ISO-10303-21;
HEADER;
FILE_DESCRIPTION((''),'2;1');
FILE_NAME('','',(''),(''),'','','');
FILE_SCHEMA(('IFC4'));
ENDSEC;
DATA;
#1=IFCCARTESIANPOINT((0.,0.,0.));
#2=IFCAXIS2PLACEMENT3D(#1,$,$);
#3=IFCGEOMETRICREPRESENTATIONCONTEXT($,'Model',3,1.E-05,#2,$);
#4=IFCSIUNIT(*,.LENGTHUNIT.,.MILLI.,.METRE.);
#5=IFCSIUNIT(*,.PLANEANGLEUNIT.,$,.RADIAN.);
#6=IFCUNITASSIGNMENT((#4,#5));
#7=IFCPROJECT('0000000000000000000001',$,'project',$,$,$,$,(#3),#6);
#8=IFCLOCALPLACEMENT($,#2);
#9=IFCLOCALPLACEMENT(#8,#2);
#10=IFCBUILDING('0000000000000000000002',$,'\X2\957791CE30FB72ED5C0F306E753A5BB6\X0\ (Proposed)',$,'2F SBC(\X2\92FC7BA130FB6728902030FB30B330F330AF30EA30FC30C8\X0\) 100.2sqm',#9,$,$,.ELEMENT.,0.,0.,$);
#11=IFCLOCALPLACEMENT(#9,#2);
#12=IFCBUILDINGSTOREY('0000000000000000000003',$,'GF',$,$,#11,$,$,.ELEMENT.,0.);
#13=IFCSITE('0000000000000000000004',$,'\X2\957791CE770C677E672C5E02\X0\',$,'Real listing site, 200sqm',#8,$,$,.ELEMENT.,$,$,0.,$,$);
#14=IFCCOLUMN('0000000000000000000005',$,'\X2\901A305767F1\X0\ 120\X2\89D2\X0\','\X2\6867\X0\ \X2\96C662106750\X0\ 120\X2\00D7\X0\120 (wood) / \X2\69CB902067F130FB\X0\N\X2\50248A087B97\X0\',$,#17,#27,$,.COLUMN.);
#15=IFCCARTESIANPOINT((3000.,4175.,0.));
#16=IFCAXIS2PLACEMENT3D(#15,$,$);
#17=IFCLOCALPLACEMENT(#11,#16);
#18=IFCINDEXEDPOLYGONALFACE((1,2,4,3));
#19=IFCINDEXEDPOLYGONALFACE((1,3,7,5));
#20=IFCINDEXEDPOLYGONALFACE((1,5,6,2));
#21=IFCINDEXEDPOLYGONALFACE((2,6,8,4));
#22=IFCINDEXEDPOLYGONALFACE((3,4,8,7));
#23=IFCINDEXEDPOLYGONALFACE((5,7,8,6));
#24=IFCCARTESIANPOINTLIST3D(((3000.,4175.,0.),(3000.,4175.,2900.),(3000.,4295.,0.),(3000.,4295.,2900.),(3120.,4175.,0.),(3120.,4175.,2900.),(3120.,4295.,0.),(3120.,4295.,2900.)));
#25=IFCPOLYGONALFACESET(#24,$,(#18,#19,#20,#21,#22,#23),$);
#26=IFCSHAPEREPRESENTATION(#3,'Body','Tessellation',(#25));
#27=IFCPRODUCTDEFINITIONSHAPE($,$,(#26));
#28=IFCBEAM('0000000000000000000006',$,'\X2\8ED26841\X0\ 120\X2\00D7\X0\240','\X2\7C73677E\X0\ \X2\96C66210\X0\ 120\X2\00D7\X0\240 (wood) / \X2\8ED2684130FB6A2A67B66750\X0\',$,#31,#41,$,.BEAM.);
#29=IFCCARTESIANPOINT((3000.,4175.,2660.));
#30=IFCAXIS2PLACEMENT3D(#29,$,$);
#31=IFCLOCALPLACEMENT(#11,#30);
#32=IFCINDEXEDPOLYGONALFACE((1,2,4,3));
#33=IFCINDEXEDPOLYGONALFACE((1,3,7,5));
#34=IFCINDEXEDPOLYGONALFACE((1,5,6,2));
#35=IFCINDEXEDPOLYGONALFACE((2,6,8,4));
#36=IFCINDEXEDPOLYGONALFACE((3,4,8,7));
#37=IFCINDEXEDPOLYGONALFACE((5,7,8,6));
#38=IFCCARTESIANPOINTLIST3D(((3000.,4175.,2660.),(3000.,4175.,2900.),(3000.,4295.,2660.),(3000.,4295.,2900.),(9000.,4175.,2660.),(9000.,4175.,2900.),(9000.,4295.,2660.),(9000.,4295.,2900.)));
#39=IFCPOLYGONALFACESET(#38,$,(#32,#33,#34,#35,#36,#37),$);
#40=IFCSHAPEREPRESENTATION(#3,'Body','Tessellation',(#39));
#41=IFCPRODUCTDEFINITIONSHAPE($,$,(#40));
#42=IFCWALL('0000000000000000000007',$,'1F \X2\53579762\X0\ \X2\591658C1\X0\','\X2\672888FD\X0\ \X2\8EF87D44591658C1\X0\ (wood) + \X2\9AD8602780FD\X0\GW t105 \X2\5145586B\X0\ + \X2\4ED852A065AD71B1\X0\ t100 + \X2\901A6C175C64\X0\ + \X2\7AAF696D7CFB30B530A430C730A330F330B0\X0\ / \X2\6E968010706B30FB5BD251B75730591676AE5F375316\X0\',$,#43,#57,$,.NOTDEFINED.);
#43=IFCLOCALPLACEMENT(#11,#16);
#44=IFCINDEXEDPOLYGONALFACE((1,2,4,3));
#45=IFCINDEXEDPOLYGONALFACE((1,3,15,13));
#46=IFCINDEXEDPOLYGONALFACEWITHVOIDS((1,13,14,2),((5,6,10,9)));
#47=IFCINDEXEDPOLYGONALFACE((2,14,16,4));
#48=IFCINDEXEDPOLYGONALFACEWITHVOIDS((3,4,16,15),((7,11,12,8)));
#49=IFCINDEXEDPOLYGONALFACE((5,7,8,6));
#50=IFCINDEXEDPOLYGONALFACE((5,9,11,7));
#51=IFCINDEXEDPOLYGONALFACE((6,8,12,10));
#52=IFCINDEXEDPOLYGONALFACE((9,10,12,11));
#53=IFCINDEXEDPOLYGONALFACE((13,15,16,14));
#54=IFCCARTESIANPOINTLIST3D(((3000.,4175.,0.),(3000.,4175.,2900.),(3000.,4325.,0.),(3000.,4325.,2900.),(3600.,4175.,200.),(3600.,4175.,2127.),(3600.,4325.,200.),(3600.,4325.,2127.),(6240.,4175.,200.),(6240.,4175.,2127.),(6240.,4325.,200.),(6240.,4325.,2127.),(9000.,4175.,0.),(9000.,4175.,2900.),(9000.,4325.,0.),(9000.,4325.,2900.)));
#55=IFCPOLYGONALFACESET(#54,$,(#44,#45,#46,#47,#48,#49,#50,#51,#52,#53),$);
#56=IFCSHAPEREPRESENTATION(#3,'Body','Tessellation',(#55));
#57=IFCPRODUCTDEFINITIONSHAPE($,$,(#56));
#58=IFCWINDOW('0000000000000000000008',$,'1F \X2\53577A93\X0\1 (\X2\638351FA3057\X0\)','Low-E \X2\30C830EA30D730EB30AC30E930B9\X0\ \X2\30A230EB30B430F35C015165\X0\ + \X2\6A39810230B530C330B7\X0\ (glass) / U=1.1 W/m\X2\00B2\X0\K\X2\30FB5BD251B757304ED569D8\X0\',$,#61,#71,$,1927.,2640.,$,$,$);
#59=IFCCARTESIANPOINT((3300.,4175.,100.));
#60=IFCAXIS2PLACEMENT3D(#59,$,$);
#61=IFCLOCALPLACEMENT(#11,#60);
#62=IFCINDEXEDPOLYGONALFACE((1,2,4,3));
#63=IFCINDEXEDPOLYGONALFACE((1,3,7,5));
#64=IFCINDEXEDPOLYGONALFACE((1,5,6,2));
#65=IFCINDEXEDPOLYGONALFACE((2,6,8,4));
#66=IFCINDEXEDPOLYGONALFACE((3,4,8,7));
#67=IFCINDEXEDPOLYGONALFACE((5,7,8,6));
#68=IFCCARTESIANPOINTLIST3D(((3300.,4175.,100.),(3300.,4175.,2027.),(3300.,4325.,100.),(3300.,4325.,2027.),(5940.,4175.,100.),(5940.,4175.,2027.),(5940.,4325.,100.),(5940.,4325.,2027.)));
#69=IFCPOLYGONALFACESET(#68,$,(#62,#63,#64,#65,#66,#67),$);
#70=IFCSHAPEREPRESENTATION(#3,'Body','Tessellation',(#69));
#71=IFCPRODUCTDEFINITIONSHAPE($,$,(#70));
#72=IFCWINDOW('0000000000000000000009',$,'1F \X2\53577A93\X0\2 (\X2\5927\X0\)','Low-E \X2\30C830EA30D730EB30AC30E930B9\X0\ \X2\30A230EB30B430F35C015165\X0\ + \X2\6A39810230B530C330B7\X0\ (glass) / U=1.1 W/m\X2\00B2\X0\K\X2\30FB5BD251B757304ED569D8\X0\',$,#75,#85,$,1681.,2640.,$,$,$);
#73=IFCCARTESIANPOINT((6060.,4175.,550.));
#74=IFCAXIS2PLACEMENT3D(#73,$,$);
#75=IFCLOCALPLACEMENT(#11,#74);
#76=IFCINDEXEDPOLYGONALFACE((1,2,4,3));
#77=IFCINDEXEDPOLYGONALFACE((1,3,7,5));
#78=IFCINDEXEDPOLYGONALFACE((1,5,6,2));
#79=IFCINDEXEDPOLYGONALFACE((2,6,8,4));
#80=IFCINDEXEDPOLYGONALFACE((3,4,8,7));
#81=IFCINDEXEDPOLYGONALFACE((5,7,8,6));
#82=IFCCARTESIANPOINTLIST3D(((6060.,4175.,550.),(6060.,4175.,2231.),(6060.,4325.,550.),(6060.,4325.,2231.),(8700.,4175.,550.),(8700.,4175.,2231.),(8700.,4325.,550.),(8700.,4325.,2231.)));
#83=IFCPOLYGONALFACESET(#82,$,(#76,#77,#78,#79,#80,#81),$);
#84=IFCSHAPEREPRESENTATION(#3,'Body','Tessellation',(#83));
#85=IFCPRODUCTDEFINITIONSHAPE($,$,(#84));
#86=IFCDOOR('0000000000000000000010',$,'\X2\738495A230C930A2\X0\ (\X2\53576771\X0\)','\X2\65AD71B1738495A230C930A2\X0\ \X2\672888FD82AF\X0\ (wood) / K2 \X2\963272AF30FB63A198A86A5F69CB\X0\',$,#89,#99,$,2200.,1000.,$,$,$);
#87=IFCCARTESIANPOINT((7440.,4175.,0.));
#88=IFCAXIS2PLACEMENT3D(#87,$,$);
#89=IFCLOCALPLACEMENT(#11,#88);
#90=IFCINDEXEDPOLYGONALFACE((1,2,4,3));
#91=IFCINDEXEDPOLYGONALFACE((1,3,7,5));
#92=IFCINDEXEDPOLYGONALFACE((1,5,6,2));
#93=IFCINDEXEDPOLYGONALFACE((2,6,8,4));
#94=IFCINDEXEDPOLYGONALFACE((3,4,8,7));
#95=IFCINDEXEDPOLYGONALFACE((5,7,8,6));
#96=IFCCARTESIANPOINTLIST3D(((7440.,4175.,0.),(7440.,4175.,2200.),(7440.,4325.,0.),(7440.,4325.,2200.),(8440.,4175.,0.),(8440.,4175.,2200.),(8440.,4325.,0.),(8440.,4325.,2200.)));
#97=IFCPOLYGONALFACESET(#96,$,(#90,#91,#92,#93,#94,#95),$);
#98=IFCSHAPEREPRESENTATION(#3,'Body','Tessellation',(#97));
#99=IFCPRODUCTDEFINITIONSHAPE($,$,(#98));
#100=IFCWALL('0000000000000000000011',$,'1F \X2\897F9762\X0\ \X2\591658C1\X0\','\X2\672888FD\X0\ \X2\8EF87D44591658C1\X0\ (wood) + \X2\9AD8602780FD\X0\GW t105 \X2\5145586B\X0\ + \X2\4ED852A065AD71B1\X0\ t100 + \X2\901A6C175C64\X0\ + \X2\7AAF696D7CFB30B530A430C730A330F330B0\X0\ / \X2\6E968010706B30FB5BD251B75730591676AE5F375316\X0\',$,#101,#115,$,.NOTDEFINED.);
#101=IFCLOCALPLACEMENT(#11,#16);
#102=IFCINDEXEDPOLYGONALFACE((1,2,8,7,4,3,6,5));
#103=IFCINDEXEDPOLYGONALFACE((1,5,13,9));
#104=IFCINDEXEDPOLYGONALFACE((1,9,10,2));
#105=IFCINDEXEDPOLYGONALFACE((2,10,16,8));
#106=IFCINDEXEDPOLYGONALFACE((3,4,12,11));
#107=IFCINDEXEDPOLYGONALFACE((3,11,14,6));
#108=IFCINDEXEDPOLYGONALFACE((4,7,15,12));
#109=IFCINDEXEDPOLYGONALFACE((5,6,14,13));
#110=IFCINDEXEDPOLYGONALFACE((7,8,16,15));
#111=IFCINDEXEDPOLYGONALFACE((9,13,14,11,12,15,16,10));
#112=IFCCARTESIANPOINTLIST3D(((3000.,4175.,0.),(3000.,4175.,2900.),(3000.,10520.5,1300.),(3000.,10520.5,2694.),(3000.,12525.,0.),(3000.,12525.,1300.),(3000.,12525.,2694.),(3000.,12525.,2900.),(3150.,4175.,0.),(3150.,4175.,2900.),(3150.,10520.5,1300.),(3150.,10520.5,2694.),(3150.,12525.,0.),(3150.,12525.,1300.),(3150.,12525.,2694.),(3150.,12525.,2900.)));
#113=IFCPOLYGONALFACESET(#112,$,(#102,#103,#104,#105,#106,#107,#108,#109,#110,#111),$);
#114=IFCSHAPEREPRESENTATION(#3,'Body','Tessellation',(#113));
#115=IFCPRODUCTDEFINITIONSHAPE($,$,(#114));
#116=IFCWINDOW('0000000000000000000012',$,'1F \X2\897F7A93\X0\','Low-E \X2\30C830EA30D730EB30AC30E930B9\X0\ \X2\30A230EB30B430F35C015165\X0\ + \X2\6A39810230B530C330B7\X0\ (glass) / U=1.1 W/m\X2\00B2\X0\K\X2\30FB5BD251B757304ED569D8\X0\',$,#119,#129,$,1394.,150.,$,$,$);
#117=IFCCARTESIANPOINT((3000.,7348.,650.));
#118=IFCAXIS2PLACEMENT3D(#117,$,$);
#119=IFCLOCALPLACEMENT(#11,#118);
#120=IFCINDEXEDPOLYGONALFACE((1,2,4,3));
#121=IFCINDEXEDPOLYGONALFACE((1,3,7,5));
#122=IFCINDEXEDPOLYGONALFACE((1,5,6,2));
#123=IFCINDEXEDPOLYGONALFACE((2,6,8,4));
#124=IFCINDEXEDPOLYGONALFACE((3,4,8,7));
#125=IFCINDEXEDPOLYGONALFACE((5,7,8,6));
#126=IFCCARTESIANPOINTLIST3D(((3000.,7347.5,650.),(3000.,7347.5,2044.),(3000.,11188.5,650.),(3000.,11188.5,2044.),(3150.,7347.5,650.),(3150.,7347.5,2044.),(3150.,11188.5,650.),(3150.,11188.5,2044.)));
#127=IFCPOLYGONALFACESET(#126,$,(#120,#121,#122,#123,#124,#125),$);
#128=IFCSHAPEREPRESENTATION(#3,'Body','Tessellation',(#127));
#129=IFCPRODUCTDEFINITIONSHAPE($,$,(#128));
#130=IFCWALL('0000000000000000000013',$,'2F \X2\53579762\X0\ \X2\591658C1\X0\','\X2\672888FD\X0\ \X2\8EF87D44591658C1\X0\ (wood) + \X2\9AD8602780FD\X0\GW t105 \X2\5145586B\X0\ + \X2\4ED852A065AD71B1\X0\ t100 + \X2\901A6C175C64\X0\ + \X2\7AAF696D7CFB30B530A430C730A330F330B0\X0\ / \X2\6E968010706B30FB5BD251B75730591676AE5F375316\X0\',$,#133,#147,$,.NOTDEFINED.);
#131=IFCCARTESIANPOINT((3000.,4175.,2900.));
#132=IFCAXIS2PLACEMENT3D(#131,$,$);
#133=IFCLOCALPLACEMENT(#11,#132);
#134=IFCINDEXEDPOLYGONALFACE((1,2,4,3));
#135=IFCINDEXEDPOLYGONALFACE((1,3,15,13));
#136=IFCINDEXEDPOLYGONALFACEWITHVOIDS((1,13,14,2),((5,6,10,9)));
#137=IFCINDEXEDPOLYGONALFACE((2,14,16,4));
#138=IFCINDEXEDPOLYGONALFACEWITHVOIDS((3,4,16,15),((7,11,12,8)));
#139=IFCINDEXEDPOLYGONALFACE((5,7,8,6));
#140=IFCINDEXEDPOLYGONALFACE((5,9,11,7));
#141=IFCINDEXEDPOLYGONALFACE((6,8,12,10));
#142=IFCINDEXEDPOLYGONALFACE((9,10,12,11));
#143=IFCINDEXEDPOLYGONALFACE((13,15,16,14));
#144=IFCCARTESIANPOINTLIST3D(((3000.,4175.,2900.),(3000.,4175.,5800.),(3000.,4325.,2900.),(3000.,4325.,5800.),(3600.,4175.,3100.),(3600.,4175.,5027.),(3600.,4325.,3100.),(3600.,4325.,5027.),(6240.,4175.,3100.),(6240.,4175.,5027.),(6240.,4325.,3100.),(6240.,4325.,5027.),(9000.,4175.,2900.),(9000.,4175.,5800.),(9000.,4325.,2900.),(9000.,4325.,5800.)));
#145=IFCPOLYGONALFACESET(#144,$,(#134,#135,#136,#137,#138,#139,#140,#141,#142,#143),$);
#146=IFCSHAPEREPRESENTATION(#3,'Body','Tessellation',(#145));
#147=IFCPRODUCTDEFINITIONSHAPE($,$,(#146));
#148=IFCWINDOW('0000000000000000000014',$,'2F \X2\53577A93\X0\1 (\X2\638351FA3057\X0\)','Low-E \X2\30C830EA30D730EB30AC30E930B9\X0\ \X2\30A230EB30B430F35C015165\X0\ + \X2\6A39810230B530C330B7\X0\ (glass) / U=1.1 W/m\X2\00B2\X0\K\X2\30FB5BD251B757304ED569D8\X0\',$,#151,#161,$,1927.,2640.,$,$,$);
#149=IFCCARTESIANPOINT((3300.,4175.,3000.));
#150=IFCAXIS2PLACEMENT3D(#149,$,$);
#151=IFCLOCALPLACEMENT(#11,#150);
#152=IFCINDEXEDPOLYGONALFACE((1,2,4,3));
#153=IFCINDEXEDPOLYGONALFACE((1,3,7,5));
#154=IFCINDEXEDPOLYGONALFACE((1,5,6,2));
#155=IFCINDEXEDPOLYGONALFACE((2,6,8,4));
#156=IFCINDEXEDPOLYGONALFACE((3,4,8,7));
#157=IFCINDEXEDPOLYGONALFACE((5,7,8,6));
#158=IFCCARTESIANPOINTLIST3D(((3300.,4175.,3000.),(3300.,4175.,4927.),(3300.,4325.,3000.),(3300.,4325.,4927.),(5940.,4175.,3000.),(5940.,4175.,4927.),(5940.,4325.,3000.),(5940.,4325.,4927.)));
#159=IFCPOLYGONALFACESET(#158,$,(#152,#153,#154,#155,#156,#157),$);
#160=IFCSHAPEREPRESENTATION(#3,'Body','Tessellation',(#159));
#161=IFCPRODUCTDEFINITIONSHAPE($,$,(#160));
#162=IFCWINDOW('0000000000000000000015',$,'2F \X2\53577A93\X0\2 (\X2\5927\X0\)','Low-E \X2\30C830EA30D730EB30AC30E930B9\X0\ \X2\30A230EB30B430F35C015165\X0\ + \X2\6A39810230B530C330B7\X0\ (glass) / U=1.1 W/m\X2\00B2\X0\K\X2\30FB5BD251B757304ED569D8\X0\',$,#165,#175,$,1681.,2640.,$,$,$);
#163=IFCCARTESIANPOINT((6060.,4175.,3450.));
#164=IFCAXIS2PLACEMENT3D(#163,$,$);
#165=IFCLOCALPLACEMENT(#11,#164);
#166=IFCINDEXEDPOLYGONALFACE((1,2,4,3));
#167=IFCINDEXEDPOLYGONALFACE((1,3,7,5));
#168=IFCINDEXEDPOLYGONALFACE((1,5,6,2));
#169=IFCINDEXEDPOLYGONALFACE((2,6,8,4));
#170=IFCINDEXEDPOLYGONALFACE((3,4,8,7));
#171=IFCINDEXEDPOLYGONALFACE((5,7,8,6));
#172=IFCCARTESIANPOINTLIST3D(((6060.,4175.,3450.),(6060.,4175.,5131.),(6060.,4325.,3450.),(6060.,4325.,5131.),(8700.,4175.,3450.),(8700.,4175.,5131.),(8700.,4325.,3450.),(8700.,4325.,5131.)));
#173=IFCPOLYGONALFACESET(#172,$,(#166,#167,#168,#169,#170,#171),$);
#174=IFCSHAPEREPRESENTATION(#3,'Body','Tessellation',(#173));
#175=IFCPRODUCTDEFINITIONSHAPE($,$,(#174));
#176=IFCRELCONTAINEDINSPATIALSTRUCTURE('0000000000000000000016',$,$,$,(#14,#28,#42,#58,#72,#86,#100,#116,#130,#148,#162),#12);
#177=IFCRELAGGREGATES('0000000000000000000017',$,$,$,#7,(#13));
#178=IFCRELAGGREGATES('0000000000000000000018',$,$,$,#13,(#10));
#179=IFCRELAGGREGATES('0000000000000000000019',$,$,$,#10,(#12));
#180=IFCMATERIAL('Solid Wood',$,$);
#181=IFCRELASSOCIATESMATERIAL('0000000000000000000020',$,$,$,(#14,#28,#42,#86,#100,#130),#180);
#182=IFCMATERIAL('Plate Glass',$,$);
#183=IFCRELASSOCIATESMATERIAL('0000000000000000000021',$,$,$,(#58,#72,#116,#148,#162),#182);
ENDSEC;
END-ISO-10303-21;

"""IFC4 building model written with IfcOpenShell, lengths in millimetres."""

from ifc_helpers import new_model, si_unit, frame, frame_2d, origin, place, context, project, spatial, rectangle, extrude, material, element, fill, save


model = new_model("IFC4")

# Units and contexts
model_context = context("Model", 3, precision=1e-05, world=origin())
ifc_project = project(units=[si_unit("LENGTHUNIT", "METRE", prefix="MILLI"), si_unit("PLANEANGLEUNIT", "RADIAN")], contexts=[model_context])

# Site, building, storey
site_placement = place(None, origin())
site = spatial("IfcSite", under=ifc_project, at=site_placement, Name="長野県松本市", ObjectType="Real listing site, 200sqm", CompositionType="ELEMENT", RefElevation=0.0)
building_placement = place(site_placement, origin())
building = spatial("IfcBuilding", under=site, at=building_placement, Name="長野・狭小の町家 (Proposed)", ObjectType="2F SBC(鋼管・木造・コンクリート) 100.2sqm", CompositionType="ELEMENT", ElevationOfRefHeight=0.0, ElevationOfTerrain=0.0)
storey_placement = place(building_placement, origin())
storey = spatial("IfcBuildingStorey", under=building, at=storey_placement, Name="GF", CompositionType="ELEMENT", Elevation=0.0)

# Column
ifc_material_1 = material(Name="Solid Wood")
column_placement = place(storey_placement, frame((3000.0, 4175.0, 0.0)))
element("IfcColumn", 1, at=column_placement, inside=storey, material=ifc_material_1, Name="通し柱 120角", Description="桧 集成材 120×120 (wood) / 構造柱・N値計算", PredefinedType="COLUMN", context=model_context, shape_type="SweptSolid", body=[
    extrude(rectangle(XDim=120.0, YDim=120.0, at=frame_2d((60.0, 60.0))), frame((3000.0, 4175.0, 0.0)), (0.0, 0.0, 1.0), 2900.0),
])

# Beam
beam_1_placement = place(storey_placement, frame((3000.0, 4175.0, 2660.0)))
element("IfcBeam", 2, at=beam_1_placement, inside=storey, material=ifc_material_1, Name="軒桁 120×240", Description="米松 集成 120×240 (wood) / 軒桁・横架材", PredefinedType="BEAM", context=model_context, shape_type="SweptSolid", body=[
    extrude(rectangle(XDim=6000.0, YDim=120.0, at=frame_2d((3000.0, 60.0))), frame((3000.0, 4175.0, 2660.0)), (0.0, 0.0, 1.0), 240.0),
])

# Wall, openings, windows, door
wall_1_placement = place(storey_placement, frame((3000.0, 4175.0, 0.0)))
wall_1 = element("IfcWall", 3, at=wall_1_placement, inside=storey, material=ifc_material_1, Name="1F 南面 外壁", Description="木製 軸組外壁 (wood) + 高性能GW t105 充填 + 付加断熱 t100 + 通気層 + 窯業系サイディング / 準耐火・寒冷地外皮強化", PredefinedType="NOTDEFINED", context=model_context, shape_type="SweptSolid", body=[
    extrude(rectangle(XDim=6000.0, YDim=150.0, at=frame_2d((3000.0, 75.0))), frame((3000.0, 4175.0, 0.0)), (0.0, 0.0, 1.0), 2900.0),
])
opening_1_placement = place(storey_placement, frame((3300.0, 4175.0, 100.0)))
opening_1 = element("IfcOpeningElement", 4, at=opening_1_placement, cuts=wall_1, PredefinedType="NOTDEFINED", context=model_context, shape_type="SweptSolid", body=[
    extrude(rectangle(XDim=2640.0, YDim=150.0, at=frame_2d((1320.0, 75.0))), frame((3300.0, 4175.0, 100.0)), (0.0, 0.0, 1.0), 1927.0),
])
opening_2_placement = place(storey_placement, frame((6060.0, 4175.0, 550.0)))
opening_2 = element("IfcOpeningElement", 5, at=opening_2_placement, cuts=wall_1, PredefinedType="NOTDEFINED", context=model_context, shape_type="SweptSolid", body=[
    extrude(rectangle(XDim=2640.0, YDim=150.0, at=frame_2d((1320.0, 75.0))), frame((6060.0, 4175.0, 550.0)), (0.0, 0.0, 1.0), 1681.0),
])
opening_3_placement = place(storey_placement, frame((7440.0, 4175.0, 0.0)))
opening_3 = element("IfcOpeningElement", 6, at=opening_3_placement, cuts=wall_1, PredefinedType="NOTDEFINED", context=model_context, shape_type="SweptSolid", body=[
    extrude(rectangle(XDim=1000.0, YDim=150.0, at=frame_2d((500.0, 75.0))), frame((7440.0, 4175.0, 0.0)), (0.0, 0.0, 1.0), 2200.0),
])
ifc_material_2 = material(Name="Plate Glass")
window_1_placement = place(storey_placement, frame((3300.0, 4175.0, 100.0)))
window_1 = element("IfcWindow", 7, at=window_1_placement, inside=storey, material=ifc_material_2, Name="1F 南窓1 (掃出し)", Description="Low-E トリプルガラス アルゴン封入 + 樹脂サッシ (glass) / U=1.1 W/m²K・寒冷地仕様", OverallHeight=1927.0, OverallWidth=2640.0, context=model_context, shape_type="SweptSolid", body=[
    extrude(rectangle(XDim=2640.0, YDim=150.0, at=frame_2d((1320.0, 75.0))), frame((3300.0, 4175.0, 100.0)), (0.0, 0.0, 1.0), 1927.0),
])
fill(opening_1, window_1)
window_2_placement = place(storey_placement, frame((6060.0, 4175.0, 550.0)))
window_2 = element("IfcWindow", 8, at=window_2_placement, inside=storey, material=ifc_material_2, Name="1F 南窓2 (大)", Description="Low-E トリプルガラス アルゴン封入 + 樹脂サッシ (glass) / U=1.1 W/m²K・寒冷地仕様", OverallHeight=1681.0, OverallWidth=2640.0, context=model_context, shape_type="SweptSolid", body=[
    extrude(rectangle(XDim=2640.0, YDim=150.0, at=frame_2d((1320.0, 75.0))), frame((6060.0, 4175.0, 550.0)), (0.0, 0.0, 1.0), 1681.0),
])
fill(opening_2, window_2)
door_placement = place(storey_placement, frame((7440.0, 4175.0, 0.0)))
door = element("IfcDoor", 9, at=door_placement, inside=storey, material=ifc_material_1, Name="玄関ドア (南東)", Description="断熱玄関ドア 木製芯 (wood) / K2 防犯・採風機構", OverallHeight=2200.0, OverallWidth=1000.0, context=model_context, shape_type="SweptSolid", body=[
    extrude(rectangle(XDim=1000.0, YDim=150.0, at=frame_2d((500.0, 75.0))), frame((7440.0, 4175.0, 0.0)), (0.0, 0.0, 1.0), 2200.0),
])
fill(opening_3, door)

# Wall, opening, window
wall_2_placement = place(storey_placement, frame((3000.0, 4175.0, 0.0)))
wall_2 = element("IfcWall", 10, at=wall_2_placement, inside=storey, material=ifc_material_1, Name="1F 西面 外壁", Description="木製 軸組外壁 (wood) + 高性能GW t105 充填 + 付加断熱 t100 + 通気層 + 窯業系サイディング / 準耐火・寒冷地外皮強化", PredefinedType="NOTDEFINED", context=model_context, shape_type="SweptSolid", body=[
    extrude(rectangle(XDim=150.0, YDim=8350.0, at=frame_2d((75.0, 4175.0))), frame((3000.0, 4175.0, 0.0)), (0.0, 0.0, 1.0), 2900.0),
])
opening_4_placement = place(storey_placement, frame((3000.0, 7348.0, 650.0)))
opening_4 = element("IfcOpeningElement", 11, at=opening_4_placement, cuts=wall_2, PredefinedType="NOTDEFINED", context=model_context, shape_type="SweptSolid", body=[
    extrude(rectangle(XDim=150.0, YDim=3841.0, at=frame_2d((75.0, 1920.0))), frame((3000.0, 7348.0, 650.0)), (0.0, 0.0, 1.0), 1394.0),
])
window_3_placement = place(storey_placement, frame((3000.0, 7348.0, 650.0)))
window_3 = element("IfcWindow", 12, at=window_3_placement, inside=storey, material=ifc_material_2, Name="1F 西窓", Description="Low-E トリプルガラス アルゴン封入 + 樹脂サッシ (glass) / U=1.1 W/m²K・寒冷地仕様", OverallHeight=1394.0, OverallWidth=150.0, context=model_context, shape_type="SweptSolid", body=[
    extrude(rectangle(XDim=150.0, YDim=3841.0, at=frame_2d((75.0, 1920.0))), frame((3000.0, 7348.0, 650.0)), (0.0, 0.0, 1.0), 1394.0),
])
fill(opening_4, window_3)

# Wall, openings, windows
wall_3_placement = place(storey_placement, frame((3000.0, 4175.0, 2900.0)))
wall_3 = element("IfcWall", 13, at=wall_3_placement, inside=storey, material=ifc_material_1, Name="2F 南面 外壁", Description="木製 軸組外壁 (wood) + 高性能GW t105 充填 + 付加断熱 t100 + 通気層 + 窯業系サイディング / 準耐火・寒冷地外皮強化", PredefinedType="NOTDEFINED", context=model_context, shape_type="SweptSolid", body=[
    extrude(rectangle(XDim=6000.0, YDim=150.0, at=frame_2d((3000.0, 75.0))), frame((3000.0, 4175.0, 2900.0)), (0.0, 0.0, 1.0), 2900.0),
])
opening_5_placement = place(storey_placement, frame((3300.0, 4175.0, 3000.0)))
opening_5 = element("IfcOpeningElement", 14, at=opening_5_placement, cuts=wall_3, PredefinedType="NOTDEFINED", context=model_context, shape_type="SweptSolid", body=[
    extrude(rectangle(XDim=2640.0, YDim=150.0, at=frame_2d((1320.0, 75.0))), frame((3300.0, 4175.0, 3000.0)), (0.0, 0.0, 1.0), 1927.0),
])
opening_6_placement = place(storey_placement, frame((6060.0, 4175.0, 3450.0)))
opening_6 = element("IfcOpeningElement", 15, at=opening_6_placement, cuts=wall_3, PredefinedType="NOTDEFINED", context=model_context, shape_type="SweptSolid", body=[
    extrude(rectangle(XDim=2640.0, YDim=150.0, at=frame_2d((1320.0, 75.0))), frame((6060.0, 4175.0, 3450.0)), (0.0, 0.0, 1.0), 1681.0),
])
window_4_placement = place(storey_placement, frame((3300.0, 4175.0, 3000.0)))
window_4 = element("IfcWindow", 16, at=window_4_placement, inside=storey, material=ifc_material_2, Name="2F 南窓1 (掃出し)", Description="Low-E トリプルガラス アルゴン封入 + 樹脂サッシ (glass) / U=1.1 W/m²K・寒冷地仕様", OverallHeight=1927.0, OverallWidth=2640.0, context=model_context, shape_type="SweptSolid", body=[
    extrude(rectangle(XDim=2640.0, YDim=150.0, at=frame_2d((1320.0, 75.0))), frame((3300.0, 4175.0, 3000.0)), (0.0, 0.0, 1.0), 1927.0),
])
fill(opening_5, window_4)
window_5_placement = place(storey_placement, frame((6060.0, 4175.0, 3450.0)))
window_5 = element("IfcWindow", 17, at=window_5_placement, inside=storey, material=ifc_material_2, Name="2F 南窓2 (大)", Description="Low-E トリプルガラス アルゴン封入 + 樹脂サッシ (glass) / U=1.1 W/m²K・寒冷地仕様", OverallHeight=1681.0, OverallWidth=2640.0, context=model_context, shape_type="SweptSolid", body=[
    extrude(rectangle(XDim=2640.0, YDim=150.0, at=frame_2d((1320.0, 75.0))), frame((6060.0, 4175.0, 3450.0)), (0.0, 0.0, 1.0), 1681.0),
])
fill(opening_6, window_5)

save(model, "model.ifc")
